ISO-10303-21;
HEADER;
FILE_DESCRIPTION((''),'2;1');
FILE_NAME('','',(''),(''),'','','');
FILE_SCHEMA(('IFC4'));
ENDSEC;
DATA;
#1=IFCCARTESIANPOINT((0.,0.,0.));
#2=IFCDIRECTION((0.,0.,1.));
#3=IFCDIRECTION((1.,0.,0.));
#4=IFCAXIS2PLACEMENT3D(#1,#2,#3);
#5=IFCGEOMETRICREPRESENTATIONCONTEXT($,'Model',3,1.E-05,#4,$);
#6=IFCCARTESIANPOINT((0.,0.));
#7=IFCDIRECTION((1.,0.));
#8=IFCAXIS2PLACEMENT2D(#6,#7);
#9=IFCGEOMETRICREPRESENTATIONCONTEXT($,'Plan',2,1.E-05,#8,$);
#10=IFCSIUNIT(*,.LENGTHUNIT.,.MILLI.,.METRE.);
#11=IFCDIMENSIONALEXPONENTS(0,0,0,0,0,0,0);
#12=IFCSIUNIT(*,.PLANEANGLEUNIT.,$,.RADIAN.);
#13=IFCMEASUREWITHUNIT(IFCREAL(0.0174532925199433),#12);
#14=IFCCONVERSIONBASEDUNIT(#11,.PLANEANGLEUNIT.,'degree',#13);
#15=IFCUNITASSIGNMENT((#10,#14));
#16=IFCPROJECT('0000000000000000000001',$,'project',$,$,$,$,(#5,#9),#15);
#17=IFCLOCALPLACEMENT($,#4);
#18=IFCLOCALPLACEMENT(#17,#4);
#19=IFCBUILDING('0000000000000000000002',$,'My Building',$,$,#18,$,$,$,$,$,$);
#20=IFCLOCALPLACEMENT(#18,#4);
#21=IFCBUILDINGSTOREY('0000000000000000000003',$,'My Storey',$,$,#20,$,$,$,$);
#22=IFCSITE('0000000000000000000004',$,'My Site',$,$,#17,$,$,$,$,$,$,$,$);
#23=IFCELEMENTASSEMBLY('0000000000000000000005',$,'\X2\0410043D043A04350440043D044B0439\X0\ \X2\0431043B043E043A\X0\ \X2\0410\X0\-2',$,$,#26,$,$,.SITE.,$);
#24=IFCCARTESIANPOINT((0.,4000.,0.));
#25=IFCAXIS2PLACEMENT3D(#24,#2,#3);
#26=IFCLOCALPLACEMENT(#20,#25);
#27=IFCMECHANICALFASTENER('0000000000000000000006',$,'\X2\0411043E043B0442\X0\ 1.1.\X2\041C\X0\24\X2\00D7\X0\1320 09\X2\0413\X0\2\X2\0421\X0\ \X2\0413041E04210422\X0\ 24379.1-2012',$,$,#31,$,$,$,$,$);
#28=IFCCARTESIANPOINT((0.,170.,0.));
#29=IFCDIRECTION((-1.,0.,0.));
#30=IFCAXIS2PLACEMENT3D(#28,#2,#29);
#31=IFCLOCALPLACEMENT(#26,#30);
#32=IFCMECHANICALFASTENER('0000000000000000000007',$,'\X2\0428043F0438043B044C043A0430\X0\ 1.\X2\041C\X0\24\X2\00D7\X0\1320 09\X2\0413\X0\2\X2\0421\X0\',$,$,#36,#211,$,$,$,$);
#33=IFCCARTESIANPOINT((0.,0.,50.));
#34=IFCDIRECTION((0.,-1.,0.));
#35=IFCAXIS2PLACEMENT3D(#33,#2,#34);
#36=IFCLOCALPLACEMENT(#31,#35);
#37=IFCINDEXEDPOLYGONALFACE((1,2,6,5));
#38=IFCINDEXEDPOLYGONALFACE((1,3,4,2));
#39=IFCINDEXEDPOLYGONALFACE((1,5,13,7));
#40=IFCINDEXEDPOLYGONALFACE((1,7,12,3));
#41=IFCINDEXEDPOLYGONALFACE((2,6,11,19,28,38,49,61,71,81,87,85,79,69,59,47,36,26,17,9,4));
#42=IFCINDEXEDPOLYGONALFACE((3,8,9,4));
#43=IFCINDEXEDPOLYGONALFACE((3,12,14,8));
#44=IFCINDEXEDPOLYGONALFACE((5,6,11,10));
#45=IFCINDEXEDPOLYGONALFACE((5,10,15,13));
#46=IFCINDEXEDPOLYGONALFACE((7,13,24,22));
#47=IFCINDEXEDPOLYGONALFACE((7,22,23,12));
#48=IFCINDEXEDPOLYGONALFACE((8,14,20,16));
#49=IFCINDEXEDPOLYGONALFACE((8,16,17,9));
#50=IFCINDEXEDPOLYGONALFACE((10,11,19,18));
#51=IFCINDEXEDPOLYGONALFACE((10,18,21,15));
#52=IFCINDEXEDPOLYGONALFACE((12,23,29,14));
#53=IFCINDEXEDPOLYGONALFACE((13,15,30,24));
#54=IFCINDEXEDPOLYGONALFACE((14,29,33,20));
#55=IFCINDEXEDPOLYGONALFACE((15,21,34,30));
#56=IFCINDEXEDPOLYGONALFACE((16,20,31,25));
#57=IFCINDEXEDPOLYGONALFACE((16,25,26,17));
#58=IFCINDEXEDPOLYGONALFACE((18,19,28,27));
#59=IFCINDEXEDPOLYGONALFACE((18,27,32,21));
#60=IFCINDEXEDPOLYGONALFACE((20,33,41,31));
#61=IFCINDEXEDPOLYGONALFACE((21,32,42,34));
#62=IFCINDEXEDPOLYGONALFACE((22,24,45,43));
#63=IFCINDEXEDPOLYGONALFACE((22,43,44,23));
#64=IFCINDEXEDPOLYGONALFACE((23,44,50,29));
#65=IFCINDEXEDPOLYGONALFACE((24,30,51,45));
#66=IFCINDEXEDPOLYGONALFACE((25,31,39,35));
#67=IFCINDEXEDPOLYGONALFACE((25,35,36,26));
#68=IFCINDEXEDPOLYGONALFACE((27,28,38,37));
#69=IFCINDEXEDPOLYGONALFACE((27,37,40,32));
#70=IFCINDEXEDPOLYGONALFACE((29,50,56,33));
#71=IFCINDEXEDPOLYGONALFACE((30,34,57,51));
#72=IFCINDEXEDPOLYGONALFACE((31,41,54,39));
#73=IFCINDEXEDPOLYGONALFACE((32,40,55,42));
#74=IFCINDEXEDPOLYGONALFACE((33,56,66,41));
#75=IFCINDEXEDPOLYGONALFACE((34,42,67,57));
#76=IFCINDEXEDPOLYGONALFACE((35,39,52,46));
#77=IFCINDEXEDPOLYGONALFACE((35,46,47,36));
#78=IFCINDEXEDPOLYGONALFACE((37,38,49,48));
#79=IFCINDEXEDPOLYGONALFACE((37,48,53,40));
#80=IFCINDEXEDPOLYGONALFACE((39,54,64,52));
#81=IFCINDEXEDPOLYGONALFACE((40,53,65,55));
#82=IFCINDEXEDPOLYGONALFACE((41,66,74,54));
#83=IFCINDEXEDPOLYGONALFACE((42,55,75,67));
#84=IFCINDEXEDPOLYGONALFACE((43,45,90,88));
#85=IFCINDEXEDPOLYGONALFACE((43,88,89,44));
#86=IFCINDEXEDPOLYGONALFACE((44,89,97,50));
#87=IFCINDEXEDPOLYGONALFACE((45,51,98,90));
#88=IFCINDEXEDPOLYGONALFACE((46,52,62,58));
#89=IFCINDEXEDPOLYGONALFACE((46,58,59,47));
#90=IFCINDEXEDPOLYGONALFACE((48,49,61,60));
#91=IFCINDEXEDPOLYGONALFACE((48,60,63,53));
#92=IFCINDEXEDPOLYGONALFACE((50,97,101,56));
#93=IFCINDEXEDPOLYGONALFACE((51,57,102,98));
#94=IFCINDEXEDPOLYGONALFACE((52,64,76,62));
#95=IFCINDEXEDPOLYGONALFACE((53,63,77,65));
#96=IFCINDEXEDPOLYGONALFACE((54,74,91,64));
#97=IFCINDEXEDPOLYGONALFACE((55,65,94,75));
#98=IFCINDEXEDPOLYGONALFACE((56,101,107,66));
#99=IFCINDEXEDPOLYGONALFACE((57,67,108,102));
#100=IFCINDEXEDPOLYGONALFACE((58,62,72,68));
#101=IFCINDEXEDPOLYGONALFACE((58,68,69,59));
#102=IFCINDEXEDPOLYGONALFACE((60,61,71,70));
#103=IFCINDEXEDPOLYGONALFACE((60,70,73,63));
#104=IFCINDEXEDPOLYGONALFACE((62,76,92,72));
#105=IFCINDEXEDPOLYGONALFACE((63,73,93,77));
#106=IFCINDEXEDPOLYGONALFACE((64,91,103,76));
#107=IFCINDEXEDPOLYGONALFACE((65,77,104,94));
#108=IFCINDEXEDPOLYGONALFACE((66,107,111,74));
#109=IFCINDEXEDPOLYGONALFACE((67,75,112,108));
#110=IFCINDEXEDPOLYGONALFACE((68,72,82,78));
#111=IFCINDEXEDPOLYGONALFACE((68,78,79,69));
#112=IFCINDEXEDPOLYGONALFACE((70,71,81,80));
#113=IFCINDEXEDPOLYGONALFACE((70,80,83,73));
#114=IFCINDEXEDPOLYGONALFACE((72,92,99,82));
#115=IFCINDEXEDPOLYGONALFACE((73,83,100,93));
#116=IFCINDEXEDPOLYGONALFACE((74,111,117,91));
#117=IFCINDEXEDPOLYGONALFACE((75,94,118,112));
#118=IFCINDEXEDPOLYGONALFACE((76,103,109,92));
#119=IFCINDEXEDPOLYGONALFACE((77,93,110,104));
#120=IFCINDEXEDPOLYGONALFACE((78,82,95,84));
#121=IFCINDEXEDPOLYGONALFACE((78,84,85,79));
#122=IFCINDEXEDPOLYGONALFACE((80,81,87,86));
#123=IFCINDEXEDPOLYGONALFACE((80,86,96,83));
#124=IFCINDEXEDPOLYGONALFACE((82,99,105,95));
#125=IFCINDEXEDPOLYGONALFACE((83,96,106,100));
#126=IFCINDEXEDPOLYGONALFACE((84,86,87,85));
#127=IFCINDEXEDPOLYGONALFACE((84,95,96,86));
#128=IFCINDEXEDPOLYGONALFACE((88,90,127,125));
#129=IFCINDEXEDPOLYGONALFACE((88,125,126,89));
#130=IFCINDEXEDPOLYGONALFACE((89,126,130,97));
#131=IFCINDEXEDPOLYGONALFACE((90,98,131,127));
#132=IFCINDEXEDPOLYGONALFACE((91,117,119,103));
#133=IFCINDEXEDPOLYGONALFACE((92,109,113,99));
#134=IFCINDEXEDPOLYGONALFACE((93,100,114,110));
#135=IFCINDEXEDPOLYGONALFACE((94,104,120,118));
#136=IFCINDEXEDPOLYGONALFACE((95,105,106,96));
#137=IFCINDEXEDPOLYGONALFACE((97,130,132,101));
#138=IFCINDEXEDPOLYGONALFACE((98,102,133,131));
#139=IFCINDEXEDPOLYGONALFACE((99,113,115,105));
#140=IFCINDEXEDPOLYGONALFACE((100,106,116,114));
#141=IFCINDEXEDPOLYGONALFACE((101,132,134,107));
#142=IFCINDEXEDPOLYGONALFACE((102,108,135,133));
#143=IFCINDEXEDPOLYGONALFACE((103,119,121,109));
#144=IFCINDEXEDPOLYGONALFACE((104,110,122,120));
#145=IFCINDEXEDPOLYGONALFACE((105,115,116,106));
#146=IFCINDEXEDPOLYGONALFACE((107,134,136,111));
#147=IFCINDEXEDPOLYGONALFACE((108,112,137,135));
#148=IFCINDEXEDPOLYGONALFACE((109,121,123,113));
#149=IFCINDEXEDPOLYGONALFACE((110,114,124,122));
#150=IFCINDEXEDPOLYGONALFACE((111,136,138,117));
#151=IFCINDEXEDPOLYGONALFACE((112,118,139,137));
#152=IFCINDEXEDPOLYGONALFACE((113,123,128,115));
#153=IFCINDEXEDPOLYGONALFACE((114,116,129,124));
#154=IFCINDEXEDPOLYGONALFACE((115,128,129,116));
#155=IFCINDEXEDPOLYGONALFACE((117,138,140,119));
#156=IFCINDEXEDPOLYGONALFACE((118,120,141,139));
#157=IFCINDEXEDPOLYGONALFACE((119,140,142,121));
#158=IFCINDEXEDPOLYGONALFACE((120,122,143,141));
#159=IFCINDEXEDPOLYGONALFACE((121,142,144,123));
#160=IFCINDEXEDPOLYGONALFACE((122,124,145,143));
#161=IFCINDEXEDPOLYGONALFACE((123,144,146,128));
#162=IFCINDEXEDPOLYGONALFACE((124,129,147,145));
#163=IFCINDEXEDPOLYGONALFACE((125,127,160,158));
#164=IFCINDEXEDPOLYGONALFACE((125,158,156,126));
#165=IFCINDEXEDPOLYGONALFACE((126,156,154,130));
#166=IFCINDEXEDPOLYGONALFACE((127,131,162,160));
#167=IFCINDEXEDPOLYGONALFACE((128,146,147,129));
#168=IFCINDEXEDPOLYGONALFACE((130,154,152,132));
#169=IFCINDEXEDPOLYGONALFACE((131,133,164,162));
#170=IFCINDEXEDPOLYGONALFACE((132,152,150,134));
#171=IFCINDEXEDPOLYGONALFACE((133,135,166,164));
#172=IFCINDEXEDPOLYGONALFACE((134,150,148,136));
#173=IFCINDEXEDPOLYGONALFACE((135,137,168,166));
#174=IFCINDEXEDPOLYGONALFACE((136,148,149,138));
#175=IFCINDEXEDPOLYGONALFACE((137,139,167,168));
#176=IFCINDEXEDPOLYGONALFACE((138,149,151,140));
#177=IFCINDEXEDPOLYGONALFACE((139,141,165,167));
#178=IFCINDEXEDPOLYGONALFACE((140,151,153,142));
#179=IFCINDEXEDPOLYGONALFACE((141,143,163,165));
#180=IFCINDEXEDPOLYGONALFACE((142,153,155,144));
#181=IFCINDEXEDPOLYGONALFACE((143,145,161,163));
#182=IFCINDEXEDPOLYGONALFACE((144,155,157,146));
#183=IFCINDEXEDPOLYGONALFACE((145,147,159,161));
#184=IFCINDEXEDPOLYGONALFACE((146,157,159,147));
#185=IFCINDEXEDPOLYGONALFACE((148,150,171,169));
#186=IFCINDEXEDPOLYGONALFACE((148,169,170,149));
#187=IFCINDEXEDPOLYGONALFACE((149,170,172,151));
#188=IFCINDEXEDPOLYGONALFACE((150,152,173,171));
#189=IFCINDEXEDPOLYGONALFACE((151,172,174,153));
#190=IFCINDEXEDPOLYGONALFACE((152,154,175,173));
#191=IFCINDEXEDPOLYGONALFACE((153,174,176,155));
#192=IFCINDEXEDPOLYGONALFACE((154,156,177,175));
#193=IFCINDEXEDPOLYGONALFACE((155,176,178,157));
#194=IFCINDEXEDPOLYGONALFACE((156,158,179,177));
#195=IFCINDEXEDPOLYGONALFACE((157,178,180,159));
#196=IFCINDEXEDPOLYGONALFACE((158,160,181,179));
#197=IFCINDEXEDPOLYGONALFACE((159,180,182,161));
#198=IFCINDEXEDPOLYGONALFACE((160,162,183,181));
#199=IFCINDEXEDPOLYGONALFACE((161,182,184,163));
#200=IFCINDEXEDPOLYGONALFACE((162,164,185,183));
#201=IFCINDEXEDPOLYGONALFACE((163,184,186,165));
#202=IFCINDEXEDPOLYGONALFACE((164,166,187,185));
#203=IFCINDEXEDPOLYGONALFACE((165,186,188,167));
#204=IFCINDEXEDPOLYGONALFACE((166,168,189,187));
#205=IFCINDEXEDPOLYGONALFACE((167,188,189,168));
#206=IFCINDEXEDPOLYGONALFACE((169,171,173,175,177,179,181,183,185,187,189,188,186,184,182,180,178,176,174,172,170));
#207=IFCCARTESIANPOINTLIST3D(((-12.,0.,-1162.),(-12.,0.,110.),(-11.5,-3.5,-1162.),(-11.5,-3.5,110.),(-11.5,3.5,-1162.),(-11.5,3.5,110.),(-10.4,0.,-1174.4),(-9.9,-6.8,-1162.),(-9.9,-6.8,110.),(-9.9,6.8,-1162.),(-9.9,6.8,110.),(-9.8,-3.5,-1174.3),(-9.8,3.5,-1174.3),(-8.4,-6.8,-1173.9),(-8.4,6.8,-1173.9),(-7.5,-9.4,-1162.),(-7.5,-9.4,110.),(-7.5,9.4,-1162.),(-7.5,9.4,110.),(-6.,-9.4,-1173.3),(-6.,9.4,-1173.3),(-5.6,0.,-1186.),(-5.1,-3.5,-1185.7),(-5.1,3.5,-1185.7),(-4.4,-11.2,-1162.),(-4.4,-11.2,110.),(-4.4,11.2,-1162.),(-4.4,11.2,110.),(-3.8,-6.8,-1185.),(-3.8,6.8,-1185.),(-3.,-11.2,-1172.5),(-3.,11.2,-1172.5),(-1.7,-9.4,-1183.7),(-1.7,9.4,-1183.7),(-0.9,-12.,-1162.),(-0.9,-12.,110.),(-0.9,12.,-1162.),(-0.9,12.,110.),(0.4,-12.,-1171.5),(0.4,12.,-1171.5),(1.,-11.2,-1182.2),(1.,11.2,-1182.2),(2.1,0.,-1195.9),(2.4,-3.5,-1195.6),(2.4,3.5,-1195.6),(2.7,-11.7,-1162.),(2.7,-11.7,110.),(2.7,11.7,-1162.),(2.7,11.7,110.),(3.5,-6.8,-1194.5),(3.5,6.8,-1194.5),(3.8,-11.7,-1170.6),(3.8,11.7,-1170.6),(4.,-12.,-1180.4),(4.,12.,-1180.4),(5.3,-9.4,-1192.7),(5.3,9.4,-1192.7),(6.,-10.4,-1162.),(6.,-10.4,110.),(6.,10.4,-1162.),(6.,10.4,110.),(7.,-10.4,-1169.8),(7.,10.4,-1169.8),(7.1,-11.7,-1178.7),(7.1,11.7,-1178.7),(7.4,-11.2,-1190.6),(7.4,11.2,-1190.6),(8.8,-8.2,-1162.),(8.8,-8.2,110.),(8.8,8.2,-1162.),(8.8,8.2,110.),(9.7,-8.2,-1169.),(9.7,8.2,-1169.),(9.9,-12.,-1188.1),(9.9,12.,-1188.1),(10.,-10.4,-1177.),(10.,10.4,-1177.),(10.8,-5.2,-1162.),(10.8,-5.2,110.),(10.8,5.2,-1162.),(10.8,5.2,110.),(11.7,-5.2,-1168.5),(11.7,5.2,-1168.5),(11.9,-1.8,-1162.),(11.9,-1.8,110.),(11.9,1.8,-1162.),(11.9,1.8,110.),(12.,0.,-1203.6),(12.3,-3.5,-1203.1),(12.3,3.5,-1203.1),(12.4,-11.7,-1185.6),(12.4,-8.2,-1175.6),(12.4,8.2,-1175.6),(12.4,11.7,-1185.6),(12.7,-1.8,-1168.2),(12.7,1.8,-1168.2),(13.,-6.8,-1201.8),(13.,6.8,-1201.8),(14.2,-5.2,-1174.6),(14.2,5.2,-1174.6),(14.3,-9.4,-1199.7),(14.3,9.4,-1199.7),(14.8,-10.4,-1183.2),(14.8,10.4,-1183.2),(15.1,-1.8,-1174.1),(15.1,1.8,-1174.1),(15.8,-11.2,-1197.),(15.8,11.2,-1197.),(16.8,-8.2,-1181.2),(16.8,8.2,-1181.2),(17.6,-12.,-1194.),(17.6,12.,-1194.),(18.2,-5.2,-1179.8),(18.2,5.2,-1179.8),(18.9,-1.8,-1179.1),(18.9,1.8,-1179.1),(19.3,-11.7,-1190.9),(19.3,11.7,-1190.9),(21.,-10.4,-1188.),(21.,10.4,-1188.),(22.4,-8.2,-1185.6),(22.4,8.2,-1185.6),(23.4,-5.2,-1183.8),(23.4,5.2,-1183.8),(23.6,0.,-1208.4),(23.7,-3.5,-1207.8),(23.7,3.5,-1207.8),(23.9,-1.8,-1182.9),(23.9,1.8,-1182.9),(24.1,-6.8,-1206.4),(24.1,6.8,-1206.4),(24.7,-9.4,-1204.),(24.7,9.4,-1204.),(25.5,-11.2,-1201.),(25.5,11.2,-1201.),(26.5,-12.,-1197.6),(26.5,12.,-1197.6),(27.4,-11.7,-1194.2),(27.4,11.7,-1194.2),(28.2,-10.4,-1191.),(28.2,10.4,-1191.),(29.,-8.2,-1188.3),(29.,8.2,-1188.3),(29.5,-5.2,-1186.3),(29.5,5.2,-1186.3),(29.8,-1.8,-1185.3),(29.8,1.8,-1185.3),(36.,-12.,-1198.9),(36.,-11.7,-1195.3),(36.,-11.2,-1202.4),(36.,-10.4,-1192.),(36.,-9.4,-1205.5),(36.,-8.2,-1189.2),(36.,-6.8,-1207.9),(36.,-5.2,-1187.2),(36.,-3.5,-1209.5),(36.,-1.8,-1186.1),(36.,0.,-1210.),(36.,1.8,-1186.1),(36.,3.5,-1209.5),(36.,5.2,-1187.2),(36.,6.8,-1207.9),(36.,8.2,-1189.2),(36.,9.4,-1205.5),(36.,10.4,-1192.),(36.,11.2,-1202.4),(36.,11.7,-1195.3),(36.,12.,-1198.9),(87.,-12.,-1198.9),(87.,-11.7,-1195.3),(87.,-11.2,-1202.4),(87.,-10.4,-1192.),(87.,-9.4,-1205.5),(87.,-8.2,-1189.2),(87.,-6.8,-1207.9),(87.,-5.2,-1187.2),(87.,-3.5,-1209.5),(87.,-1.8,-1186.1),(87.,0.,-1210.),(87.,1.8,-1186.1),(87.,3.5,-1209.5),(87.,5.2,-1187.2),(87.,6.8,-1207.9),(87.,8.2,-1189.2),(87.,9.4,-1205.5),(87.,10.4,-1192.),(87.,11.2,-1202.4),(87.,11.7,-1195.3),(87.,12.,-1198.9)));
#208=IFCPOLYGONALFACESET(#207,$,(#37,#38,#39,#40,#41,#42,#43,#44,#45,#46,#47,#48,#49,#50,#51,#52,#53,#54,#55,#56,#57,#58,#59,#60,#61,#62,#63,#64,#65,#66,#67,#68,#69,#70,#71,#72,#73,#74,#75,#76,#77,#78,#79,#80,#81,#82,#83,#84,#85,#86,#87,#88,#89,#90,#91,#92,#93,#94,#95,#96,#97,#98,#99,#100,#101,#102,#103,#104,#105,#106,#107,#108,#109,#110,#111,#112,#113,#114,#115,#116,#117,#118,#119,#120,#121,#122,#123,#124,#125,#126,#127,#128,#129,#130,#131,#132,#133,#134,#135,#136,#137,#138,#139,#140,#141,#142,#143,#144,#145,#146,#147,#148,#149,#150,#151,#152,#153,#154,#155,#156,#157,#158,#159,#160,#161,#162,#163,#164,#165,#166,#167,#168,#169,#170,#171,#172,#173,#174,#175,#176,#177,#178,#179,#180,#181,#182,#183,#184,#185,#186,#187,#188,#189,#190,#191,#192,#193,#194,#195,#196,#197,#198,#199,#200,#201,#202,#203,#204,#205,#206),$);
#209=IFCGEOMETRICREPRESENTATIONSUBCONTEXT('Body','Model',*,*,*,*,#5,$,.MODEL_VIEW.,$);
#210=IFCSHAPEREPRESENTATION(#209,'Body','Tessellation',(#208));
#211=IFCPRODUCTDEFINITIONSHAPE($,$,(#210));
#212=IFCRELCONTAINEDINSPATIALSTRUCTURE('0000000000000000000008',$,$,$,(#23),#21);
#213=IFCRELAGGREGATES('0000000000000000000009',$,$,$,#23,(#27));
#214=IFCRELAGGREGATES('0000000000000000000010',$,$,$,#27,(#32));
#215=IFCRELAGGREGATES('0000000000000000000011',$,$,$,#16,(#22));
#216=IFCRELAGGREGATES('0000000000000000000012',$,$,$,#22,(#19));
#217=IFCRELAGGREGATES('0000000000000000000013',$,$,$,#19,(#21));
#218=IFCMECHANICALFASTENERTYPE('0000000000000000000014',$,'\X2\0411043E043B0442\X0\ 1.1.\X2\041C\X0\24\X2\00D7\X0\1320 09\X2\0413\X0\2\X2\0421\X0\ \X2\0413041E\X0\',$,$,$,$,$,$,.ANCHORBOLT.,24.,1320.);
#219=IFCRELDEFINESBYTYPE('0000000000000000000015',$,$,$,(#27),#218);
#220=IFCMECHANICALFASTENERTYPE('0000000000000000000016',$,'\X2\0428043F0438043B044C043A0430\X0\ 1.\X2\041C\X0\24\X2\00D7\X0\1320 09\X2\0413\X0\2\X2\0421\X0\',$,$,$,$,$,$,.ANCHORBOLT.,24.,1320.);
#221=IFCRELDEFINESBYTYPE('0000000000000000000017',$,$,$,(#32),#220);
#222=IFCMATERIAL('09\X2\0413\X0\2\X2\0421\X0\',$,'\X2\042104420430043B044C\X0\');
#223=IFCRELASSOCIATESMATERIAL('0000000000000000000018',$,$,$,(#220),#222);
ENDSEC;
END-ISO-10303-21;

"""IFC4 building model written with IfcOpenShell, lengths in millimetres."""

from ifc_helpers import new_model, entity, si_unit, converted_unit, frame, origin_with_axes, origin_2d_with_axis, place, context, subcontext, project, spatial, source, transform, mapped, material, type_object, type_shapes, element, aggregate, save


model = new_model("IFC4")

# Units and contexts
model_context = context("Model", 3, precision=1e-05, world=origin_with_axes())
plan_context = context("Plan", 2, precision=1e-05, world=origin_2d_with_axis())
body_context = subcontext(model_context, "Body", "Model", "MODEL_VIEW")
ifc_project = project(units=[si_unit("LENGTHUNIT", "METRE", prefix="MILLI"), converted_unit("PLANEANGLEUNIT", "degree", entity("IfcReal", 0.0174532925199433), si_unit("PLANEANGLEUNIT", "RADIAN"), dimensions=[0, 0, 0, 0, 0, 0, 0])], contexts=[model_context, plan_context])

# Site, building, storey
site_placement = place(None, origin_with_axes())
site = spatial("IfcSite", under=ifc_project, at=site_placement, Name="My Site")
building_placement = place(site_placement, origin_with_axes())
building = spatial("IfcBuilding", under=site, at=building_placement, Name="My Building")
storey_placement = place(building_placement, origin_with_axes())
storey = spatial("IfcBuildingStorey", under=building, at=storey_placement, Name="My Storey")

# Element assembly, mechanical fasteners
ifc_material_1 = material(Name="09Г2С", Category="Сталь")
mechanical_fastener_type_1 = type_object("IfcMechanicalFastenerType", Name="Шпилька 1.М24×1320 09Г2С", NominalDiameter=24.0, NominalLength=1320.0, PredefinedType="ANCHORBOLT", material=ifc_material_1)
shared_shape_1 = source(frame((0.0, 0.0, 110.0), z_axis=(0.0, 0.0, 1.0), x_axis=(1.0, 0.0, 0.0)), body_context, "Body", "AdvancedSweptSolid", [
    entity("IfcSweptDiskSolid", entity("IfcIndexedPolyCurve", entity("IfcCartesianPointList3D", [[0.0, 0.0, 0.0], [0.0, 0.0, -1272.0], [10.5, 0.0, -1297.5], [36.0, 0.0, -1308.0], [87.0, 0.0, -1308.0]]), [entity("IfcLineIndex", [1, 2]), entity("IfcArcIndex", [2, 3, 4]), entity("IfcLineIndex", [4, 5])]), 12.0),
])
type_shapes(mechanical_fastener_type_1, [shared_shape_1])
mechanical_fastener_type_2 = type_object("IfcMechanicalFastenerType", Name="Болт 1.1.М24×1320 09Г2С ГО", NominalDiameter=24.0, NominalLength=1320.0, PredefinedType="ANCHORBOLT")
assembly_1_placement = place(storey_placement, frame((0.0, 4000.0, 0.0), z_axis=(0.0, 0.0, 1.0), x_axis=(1.0, 0.0, 0.0)))
assembly_1 = element("IfcElementAssembly", 1, at=assembly_1_placement, inside=storey, Name="Анкерный блок А-2", AssemblyPlace="SITE")
mechanical_fastener_1_placement = place(assembly_1_placement, frame((0.0, 170.0, 0.0), z_axis=(0.0, 0.0, 1.0), x_axis=(-1.0, 0.0, 0.0)))
mechanical_fastener_1 = element("IfcMechanicalFastener", 2, at=mechanical_fastener_1_placement, type_object=mechanical_fastener_type_2, Name="Болт 1.1.М24×1320 09Г2С ГОСТ 24379.1-2012")
aggregate(assembly_1, [mechanical_fastener_1])
mechanical_fastener_2_placement = place(mechanical_fastener_1_placement, frame((0.0, 0.0, 50.0), z_axis=(0.0, 0.0, 1.0), x_axis=(0.0, -1.0, 0.0)))
mechanical_fastener_2 = element("IfcMechanicalFastener", 3, at=mechanical_fastener_2_placement, type_object=mechanical_fastener_type_1, Name="Шпилька 1.М24×1320 09Г2С", context=body_context, shape_type="MappedRepresentation", body=[
    mapped(shared_shape_1, transform((0.0, 0.0, 0.0), x_axis=(1.0, 0.0, 0.0), y_axis=(0.0, 1.0, 0.0), z_axis=(0.0, 0.0, 1.0), scale=1.0)),
])

aggregate(mechanical_fastener_1, [mechanical_fastener_2])

save(model, "model.ifc")
